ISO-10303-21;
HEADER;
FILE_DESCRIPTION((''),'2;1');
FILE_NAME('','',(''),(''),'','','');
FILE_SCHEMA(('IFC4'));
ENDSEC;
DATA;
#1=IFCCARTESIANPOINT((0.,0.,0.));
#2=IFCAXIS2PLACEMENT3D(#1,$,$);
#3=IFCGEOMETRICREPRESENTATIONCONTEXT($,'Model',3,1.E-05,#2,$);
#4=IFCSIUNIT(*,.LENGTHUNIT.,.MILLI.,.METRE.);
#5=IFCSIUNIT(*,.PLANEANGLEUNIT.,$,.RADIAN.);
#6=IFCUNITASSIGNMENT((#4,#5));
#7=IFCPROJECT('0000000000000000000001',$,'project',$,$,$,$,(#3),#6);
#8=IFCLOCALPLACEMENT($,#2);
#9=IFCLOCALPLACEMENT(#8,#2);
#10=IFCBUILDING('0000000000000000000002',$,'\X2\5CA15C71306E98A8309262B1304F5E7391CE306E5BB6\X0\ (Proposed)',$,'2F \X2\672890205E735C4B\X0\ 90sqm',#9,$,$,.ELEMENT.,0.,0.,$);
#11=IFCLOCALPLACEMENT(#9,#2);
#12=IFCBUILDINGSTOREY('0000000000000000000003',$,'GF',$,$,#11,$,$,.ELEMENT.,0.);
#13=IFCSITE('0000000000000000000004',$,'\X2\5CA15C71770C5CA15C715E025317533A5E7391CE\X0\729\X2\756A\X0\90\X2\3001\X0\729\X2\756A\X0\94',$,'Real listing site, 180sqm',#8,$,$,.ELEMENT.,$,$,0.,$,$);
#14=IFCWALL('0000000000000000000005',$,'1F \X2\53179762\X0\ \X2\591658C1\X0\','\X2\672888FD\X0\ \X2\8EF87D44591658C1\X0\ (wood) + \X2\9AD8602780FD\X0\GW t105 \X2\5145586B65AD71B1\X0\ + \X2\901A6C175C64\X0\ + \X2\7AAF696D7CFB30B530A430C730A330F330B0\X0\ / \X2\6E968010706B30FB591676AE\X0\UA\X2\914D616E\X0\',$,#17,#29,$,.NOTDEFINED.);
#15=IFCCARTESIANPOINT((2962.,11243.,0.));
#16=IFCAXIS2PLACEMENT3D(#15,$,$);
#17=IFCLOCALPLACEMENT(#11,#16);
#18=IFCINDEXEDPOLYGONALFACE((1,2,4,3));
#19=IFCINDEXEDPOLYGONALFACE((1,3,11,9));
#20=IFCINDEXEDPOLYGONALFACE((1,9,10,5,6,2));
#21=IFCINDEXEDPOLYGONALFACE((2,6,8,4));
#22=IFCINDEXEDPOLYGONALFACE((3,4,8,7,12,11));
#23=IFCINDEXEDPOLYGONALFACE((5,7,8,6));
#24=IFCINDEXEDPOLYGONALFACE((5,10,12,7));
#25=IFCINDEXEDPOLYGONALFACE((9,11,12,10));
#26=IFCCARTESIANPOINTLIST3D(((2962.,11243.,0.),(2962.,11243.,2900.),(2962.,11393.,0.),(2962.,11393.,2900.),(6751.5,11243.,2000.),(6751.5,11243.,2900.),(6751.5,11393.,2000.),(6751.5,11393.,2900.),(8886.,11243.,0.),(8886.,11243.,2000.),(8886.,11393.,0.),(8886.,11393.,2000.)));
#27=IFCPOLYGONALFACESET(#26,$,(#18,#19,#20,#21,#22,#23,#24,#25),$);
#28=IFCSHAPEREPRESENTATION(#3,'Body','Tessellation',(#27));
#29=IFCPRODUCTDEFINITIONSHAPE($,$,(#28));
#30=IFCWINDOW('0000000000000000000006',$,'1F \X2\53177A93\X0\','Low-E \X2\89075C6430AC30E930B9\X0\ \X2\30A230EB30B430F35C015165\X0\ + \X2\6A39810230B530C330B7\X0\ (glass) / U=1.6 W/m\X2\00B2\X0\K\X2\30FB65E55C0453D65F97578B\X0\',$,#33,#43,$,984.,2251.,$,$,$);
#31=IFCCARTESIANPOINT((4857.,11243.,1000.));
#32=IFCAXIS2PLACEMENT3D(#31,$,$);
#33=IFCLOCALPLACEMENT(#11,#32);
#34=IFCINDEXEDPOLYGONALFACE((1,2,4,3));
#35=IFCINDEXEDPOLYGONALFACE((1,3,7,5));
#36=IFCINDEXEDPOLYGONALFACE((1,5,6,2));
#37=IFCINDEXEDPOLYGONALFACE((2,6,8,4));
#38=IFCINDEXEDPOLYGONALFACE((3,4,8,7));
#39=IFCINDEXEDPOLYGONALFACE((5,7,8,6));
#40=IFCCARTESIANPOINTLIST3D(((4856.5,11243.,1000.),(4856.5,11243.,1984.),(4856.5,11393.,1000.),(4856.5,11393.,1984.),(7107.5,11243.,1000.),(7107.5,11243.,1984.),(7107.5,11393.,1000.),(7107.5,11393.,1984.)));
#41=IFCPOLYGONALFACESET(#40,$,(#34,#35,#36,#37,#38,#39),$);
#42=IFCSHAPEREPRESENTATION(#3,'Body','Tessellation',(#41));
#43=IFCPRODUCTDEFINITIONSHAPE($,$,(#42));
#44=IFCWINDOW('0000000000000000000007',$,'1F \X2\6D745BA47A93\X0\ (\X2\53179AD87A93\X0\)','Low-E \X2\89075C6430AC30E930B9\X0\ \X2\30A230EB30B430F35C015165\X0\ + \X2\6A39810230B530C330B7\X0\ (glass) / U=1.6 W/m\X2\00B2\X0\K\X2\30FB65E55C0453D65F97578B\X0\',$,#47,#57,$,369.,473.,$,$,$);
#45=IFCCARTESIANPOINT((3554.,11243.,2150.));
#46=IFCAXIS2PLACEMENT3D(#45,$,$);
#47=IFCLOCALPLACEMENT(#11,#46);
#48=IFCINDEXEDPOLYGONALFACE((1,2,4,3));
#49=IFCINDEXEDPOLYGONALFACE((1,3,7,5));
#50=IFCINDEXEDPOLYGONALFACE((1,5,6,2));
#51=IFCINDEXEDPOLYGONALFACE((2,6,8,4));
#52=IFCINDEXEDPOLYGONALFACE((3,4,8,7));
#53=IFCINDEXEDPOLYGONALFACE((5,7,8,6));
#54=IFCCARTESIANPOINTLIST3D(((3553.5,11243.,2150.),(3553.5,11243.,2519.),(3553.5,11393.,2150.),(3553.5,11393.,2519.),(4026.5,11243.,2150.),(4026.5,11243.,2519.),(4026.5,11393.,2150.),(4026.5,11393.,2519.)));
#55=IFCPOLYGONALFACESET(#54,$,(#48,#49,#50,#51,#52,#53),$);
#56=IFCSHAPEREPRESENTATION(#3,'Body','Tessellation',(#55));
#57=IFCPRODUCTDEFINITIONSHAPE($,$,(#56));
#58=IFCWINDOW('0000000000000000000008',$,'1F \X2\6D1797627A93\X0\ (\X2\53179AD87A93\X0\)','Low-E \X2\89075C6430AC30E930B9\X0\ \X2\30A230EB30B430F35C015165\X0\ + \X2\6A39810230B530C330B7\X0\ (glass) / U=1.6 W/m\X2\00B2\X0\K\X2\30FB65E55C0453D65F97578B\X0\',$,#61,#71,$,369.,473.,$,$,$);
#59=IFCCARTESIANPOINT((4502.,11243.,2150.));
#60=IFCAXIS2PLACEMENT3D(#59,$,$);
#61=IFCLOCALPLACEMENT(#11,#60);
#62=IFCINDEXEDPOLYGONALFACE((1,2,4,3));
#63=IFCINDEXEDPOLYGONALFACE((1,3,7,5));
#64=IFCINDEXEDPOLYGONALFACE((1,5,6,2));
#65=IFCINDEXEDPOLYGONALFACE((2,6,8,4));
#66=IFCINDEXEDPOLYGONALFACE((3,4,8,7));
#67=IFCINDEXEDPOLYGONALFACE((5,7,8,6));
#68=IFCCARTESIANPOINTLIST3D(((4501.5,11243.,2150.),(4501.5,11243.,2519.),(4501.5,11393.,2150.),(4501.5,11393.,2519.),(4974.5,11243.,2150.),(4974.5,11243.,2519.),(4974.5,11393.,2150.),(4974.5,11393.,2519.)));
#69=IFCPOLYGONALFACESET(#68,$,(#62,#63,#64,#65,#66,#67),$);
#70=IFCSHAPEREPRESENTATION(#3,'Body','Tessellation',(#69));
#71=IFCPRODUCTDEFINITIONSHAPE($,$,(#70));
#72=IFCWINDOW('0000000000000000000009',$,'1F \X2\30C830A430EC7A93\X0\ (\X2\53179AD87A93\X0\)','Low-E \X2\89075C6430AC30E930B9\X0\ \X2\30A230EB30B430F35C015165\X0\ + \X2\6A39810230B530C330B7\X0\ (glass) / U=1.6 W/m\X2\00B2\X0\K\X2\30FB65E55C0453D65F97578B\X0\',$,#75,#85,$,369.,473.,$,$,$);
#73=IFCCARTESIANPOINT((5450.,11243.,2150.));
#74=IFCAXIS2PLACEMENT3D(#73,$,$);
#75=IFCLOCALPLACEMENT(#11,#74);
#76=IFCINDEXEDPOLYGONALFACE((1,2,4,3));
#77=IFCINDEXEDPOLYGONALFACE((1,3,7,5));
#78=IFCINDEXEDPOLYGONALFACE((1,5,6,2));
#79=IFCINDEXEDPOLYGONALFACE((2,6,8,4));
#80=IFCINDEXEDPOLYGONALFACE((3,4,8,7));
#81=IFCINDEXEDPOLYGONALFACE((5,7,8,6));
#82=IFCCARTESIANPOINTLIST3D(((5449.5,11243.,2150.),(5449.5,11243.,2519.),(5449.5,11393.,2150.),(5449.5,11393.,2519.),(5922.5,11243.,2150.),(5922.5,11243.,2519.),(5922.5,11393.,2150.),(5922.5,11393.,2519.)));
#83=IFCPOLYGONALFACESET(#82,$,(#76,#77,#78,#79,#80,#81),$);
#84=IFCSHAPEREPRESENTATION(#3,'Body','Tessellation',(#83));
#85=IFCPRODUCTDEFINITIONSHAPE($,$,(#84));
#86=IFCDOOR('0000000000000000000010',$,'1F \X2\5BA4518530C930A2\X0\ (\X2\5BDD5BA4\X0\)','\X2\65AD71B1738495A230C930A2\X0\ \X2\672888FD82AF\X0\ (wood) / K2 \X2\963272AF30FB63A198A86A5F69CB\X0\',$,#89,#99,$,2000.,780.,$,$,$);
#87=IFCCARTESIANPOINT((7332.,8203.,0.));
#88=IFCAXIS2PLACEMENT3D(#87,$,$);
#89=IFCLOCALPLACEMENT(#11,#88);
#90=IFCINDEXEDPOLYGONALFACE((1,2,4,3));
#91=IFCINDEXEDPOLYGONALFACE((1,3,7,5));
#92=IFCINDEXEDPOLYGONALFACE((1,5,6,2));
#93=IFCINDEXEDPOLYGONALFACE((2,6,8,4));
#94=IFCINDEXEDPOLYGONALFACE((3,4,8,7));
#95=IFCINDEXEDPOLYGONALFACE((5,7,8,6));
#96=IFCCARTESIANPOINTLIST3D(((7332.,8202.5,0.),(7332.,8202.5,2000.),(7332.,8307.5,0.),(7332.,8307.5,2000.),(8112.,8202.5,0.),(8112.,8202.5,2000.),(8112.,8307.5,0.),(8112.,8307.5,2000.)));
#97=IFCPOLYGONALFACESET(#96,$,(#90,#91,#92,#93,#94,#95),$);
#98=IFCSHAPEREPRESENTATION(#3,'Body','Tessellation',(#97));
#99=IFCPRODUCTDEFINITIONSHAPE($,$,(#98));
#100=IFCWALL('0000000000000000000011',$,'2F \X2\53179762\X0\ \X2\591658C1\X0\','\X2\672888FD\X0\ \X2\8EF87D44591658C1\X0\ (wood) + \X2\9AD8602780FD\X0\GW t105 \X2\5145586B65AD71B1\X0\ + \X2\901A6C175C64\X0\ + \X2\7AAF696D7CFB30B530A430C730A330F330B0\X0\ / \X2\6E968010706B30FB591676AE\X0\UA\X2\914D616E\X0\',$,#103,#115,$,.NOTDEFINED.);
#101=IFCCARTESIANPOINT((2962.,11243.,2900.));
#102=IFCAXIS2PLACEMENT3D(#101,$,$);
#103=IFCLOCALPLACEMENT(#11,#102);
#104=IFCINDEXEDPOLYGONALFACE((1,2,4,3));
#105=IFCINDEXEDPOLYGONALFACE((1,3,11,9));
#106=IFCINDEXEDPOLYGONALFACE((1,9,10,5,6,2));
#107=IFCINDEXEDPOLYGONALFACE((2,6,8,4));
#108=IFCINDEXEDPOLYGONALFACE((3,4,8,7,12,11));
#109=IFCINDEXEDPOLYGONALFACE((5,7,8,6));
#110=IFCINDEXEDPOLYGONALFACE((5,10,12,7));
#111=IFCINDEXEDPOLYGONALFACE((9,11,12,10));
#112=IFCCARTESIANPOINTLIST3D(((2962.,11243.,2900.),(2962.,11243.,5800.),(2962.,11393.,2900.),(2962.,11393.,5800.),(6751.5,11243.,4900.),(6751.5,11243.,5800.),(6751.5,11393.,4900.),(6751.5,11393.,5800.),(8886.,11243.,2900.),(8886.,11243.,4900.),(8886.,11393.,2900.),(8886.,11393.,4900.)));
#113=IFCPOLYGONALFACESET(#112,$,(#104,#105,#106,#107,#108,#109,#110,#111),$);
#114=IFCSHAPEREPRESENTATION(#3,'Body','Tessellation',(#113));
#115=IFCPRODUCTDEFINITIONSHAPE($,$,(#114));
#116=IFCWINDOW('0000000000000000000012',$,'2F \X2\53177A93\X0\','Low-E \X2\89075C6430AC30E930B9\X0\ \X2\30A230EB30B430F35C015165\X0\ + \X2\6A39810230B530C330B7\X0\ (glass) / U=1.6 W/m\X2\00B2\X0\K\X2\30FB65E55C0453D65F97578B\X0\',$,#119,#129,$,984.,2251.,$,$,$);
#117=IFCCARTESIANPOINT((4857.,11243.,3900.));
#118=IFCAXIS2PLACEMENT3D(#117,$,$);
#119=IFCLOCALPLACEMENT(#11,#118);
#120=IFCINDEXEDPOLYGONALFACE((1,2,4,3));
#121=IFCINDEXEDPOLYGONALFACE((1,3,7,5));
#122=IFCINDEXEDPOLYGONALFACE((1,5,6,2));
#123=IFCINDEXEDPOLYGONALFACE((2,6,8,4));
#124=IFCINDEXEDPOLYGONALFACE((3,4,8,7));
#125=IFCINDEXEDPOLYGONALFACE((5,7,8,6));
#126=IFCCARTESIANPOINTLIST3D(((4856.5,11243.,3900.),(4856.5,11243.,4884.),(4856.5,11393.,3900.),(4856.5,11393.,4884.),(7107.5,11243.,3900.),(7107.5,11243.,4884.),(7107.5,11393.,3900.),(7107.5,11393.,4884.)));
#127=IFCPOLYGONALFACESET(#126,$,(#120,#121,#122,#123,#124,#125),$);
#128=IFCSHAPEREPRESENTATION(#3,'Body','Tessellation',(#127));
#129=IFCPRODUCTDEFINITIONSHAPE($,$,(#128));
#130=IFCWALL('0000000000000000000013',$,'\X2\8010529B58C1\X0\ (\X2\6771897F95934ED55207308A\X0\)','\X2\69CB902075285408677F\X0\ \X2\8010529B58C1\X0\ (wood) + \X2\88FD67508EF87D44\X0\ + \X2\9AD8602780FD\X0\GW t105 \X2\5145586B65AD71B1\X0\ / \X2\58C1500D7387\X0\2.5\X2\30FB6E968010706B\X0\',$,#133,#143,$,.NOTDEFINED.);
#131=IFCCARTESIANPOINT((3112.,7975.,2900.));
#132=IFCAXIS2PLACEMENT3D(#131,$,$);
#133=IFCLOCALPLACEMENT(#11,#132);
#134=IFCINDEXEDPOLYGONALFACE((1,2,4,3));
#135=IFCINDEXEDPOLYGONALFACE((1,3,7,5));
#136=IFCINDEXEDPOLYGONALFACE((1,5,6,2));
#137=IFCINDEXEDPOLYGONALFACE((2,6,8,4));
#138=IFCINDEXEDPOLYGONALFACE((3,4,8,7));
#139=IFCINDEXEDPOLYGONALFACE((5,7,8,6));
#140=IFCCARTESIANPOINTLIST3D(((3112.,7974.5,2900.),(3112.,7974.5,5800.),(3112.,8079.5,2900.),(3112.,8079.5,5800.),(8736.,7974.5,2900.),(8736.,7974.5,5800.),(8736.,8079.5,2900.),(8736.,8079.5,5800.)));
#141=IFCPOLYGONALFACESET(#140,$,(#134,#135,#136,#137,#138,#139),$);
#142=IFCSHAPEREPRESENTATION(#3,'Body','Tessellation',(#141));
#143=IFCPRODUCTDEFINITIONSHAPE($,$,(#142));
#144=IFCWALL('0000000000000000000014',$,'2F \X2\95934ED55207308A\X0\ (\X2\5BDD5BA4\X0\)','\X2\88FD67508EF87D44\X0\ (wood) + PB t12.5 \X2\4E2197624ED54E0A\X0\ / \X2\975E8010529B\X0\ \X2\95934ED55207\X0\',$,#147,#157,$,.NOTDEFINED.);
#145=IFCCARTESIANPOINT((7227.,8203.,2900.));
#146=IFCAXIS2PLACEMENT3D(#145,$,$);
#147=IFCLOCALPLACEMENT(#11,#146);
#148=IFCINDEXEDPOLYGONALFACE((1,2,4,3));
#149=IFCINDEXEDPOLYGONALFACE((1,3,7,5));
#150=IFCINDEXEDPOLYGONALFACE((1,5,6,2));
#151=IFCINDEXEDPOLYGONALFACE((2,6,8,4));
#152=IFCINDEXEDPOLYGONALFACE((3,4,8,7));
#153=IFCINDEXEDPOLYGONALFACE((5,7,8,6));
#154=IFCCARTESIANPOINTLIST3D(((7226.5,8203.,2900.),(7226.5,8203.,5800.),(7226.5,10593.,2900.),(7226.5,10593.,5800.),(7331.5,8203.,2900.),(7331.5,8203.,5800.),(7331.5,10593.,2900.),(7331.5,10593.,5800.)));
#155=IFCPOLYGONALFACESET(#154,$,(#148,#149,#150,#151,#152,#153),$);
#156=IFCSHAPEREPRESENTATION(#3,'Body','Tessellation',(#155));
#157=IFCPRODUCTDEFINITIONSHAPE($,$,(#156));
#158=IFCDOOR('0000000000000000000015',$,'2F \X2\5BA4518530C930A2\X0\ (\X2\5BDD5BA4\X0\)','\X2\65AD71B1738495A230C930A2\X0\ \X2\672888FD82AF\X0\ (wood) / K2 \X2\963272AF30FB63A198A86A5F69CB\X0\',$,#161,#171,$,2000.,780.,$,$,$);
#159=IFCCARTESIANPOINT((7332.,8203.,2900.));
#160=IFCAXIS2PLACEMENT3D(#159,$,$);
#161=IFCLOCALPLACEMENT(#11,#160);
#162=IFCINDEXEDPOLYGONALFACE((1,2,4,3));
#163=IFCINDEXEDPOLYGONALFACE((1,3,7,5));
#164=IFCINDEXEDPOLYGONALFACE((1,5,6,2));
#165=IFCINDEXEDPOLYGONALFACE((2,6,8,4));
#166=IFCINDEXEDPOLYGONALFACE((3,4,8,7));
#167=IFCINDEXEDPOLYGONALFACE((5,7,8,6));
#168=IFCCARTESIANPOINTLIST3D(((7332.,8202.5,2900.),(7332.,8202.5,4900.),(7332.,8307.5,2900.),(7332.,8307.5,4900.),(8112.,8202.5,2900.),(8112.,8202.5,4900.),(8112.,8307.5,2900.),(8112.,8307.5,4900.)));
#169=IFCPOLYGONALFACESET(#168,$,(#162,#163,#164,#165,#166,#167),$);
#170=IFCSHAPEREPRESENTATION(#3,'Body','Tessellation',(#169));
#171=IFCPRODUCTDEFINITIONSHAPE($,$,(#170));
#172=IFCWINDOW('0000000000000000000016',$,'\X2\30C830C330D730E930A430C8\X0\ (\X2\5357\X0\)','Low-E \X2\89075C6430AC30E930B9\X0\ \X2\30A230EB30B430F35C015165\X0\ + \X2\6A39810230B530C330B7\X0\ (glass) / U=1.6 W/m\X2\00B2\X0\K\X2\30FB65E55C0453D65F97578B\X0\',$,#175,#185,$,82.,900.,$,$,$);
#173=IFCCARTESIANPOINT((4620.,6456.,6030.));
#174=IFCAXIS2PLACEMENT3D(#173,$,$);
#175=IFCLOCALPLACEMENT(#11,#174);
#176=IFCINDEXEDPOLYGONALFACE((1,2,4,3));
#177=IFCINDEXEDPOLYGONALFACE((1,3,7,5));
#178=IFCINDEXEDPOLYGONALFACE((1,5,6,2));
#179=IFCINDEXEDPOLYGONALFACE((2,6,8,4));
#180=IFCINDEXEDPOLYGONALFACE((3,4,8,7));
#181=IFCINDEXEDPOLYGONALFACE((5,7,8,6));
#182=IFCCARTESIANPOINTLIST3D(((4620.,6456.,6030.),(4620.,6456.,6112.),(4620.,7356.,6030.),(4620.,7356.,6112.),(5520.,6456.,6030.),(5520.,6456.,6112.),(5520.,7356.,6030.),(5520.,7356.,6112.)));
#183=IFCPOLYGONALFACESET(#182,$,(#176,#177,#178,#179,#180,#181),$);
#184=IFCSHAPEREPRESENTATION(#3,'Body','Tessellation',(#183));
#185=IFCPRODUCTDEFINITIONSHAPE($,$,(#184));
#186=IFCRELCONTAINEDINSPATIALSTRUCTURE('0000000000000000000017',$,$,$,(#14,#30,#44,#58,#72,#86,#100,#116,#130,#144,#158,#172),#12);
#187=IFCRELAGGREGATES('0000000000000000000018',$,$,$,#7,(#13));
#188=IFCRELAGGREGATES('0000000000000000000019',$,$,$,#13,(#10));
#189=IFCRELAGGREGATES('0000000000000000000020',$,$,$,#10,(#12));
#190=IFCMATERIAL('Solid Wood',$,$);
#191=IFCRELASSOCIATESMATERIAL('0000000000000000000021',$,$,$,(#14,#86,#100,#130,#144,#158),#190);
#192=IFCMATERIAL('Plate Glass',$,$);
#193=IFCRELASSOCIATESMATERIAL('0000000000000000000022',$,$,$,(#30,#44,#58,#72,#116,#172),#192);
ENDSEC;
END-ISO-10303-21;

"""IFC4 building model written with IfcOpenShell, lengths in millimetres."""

from ifc_helpers import new_model, si_unit, frame, frame_2d, origin, place, context, project, spatial, rectangle, extrude, material, element, fill, save


model = new_model("IFC4")

# Units and contexts
model_context = context("Model", 3, precision=1e-05, world=origin())
ifc_project = project(units=[si_unit("LENGTHUNIT", "METRE", prefix="MILLI"), si_unit("PLANEANGLEUNIT", "RADIAN")], contexts=[model_context])

# Site, building, storey
site_placement = place(None, origin())
site = spatial("IfcSite", under=ifc_project, at=site_placement, Name="岡山県岡山市北区平野729番90、729番94", ObjectType="Real listing site, 180sqm", CompositionType="ELEMENT", RefElevation=0.0)
building_placement = place(site_placement, origin())
building = spatial("IfcBuilding", under=site, at=building_placement, Name="岡山の風を抱く平野の家 (Proposed)", ObjectType="2F 木造平屋 90sqm", CompositionType="ELEMENT", ElevationOfRefHeight=0.0, ElevationOfTerrain=0.0)
storey_placement = place(building_placement, origin())
storey = spatial("IfcBuildingStorey", under=building, at=storey_placement, Name="GF", CompositionType="ELEMENT", Elevation=0.0)

# Wall, openings, windows
ifc_material_1 = material(Name="Solid Wood")
wall_1_placement = place(storey_placement, frame((2962.0, 11243.0, 0.0)))
wall_1 = element("IfcWall", 1, at=wall_1_placement, inside=storey, material=ifc_material_1, Name="1F 北面 外壁", Description="木製 軸組外壁 (wood) + 高性能GW t105 充填断熱 + 通気層 + 窯業系サイディング / 準耐火・外皮UA配慮", PredefinedType="NOTDEFINED", context=model_context, shape_type="SweptSolid", body=[
    extrude(rectangle(XDim=5924.0, YDim=150.0, at=frame_2d((2962.0, 75.0))), frame((2962.0, 11243.0, 0.0)), (0.0, 0.0, 1.0), 2900.0),
])
opening_1_placement = place(storey_placement, frame((4857.0, 11243.0, 1000.0)))
opening_1 = element("IfcOpeningElement", 2, at=opening_1_placement, cuts=wall_1, PredefinedType="NOTDEFINED", context=model_context, shape_type="SweptSolid", body=[
    extrude(rectangle(XDim=2251.0, YDim=150.0, at=frame_2d((1125.0, 75.0))), frame((4857.0, 11243.0, 1000.0)), (0.0, 0.0, 1.0), 984.0),
])
opening_2_placement = place(storey_placement, frame((3554.0, 11243.0, 2150.0)))
opening_2 = element("IfcOpeningElement", 3, at=opening_2_placement, cuts=wall_1, PredefinedType="NOTDEFINED", context=model_context, shape_type="SweptSolid", body=[
    extrude(rectangle(XDim=473.0, YDim=150.0, at=frame_2d((236.0, 75.0))), frame((3554.0, 11243.0, 2150.0)), (0.0, 0.0, 1.0), 369.0),
])
opening_3_placement = place(storey_placement, frame((4502.0, 11243.0, 2150.0)))
opening_3 = element("IfcOpeningElement", 4, at=opening_3_placement, cuts=wall_1, PredefinedType="NOTDEFINED", context=model_context, shape_type="SweptSolid", body=[
    extrude(rectangle(XDim=473.0, YDim=150.0, at=frame_2d((236.0, 75.0))), frame((4502.0, 11243.0, 2150.0)), (0.0, 0.0, 1.0), 369.0),
])
opening_4_placement = place(storey_placement, frame((5450.0, 11243.0, 2150.0)))
opening_4 = element("IfcOpeningElement", 5, at=opening_4_placement, cuts=wall_1, PredefinedType="NOTDEFINED", context=model_context, shape_type="SweptSolid", body=[
    extrude(rectangle(XDim=473.0, YDim=150.0, at=frame_2d((236.0, 75.0))), frame((5450.0, 11243.0, 2150.0)), (0.0, 0.0, 1.0), 369.0),
])
ifc_material_2 = material(Name="Plate Glass")
window_1_placement = place(storey_placement, frame((4857.0, 11243.0, 1000.0)))
window_1 = element("IfcWindow", 6, at=window_1_placement, inside=storey, material=ifc_material_2, Name="1F 北窓", Description="Low-E 複層ガラス アルゴン封入 + 樹脂サッシ (glass) / U=1.6 W/m²K・日射取得型", OverallHeight=984.0, OverallWidth=2251.0, context=model_context, shape_type="SweptSolid", body=[
    extrude(rectangle(XDim=2251.0, YDim=150.0, at=frame_2d((1125.0, 75.0))), frame((4857.0, 11243.0, 1000.0)), (0.0, 0.0, 1.0), 984.0),
])
fill(opening_1, window_1)
window_2_placement = place(storey_placement, frame((3554.0, 11243.0, 2150.0)))
window_2 = element("IfcWindow", 7, at=window_2_placement, inside=storey, material=ifc_material_2, Name="1F 浴室窓 (北高窓)", Description="Low-E 複層ガラス アルゴン封入 + 樹脂サッシ (glass) / U=1.6 W/m²K・日射取得型", OverallHeight=369.0, OverallWidth=473.0, context=model_context, shape_type="SweptSolid", body=[
    extrude(rectangle(XDim=473.0, YDim=150.0, at=frame_2d((236.0, 75.0))), frame((3554.0, 11243.0, 2150.0)), (0.0, 0.0, 1.0), 369.0),
])
fill(opening_2, window_2)
window_3_placement = place(storey_placement, frame((4502.0, 11243.0, 2150.0)))
window_3 = element("IfcWindow", 8, at=window_3_placement, inside=storey, material=ifc_material_2, Name="1F 洗面窓 (北高窓)", Description="Low-E 複層ガラス アルゴン封入 + 樹脂サッシ (glass) / U=1.6 W/m²K・日射取得型", OverallHeight=369.0, OverallWidth=473.0, context=model_context, shape_type="SweptSolid", body=[
    extrude(rectangle(XDim=473.0, YDim=150.0, at=frame_2d((236.0, 75.0))), frame((4502.0, 11243.0, 2150.0)), (0.0, 0.0, 1.0), 369.0),
])
fill(opening_3, window_3)
window_4_placement = place(storey_placement, frame((5450.0, 11243.0, 2150.0)))
window_4 = element("IfcWindow", 9, at=window_4_placement, inside=storey, material=ifc_material_2, Name="1F トイレ窓 (北高窓)", Description="Low-E 複層ガラス アルゴン封入 + 樹脂サッシ (glass) / U=1.6 W/m²K・日射取得型", OverallHeight=369.0, OverallWidth=473.0, context=model_context, shape_type="SweptSolid", body=[
    extrude(rectangle(XDim=473.0, YDim=150.0, at=frame_2d((236.0, 75.0))), frame((5450.0, 11243.0, 2150.0)), (0.0, 0.0, 1.0), 369.0),
])
fill(opening_4, window_4)

# Door
door_1_placement = place(storey_placement, frame((7332.0, 8203.0, 0.0)))
element("IfcDoor", 10, at=door_1_placement, inside=storey, material=ifc_material_1, Name="1F 室内ドア (寝室)", Description="断熱玄関ドア 木製芯 (wood) / K2 防犯・採風機構", OverallHeight=2000.0, OverallWidth=780.0, context=model_context, shape_type="SweptSolid", body=[
    extrude(rectangle(XDim=780.0, YDim=105.0, at=frame_2d((390.0, 52.0))), frame((7332.0, 8203.0, 0.0)), (0.0, 0.0, 1.0), 2000.0),
])

# Wall, opening, window
wall_2_placement = place(storey_placement, frame((2962.0, 11243.0, 2900.0)))
wall_2 = element("IfcWall", 11, at=wall_2_placement, inside=storey, material=ifc_material_1, Name="2F 北面 外壁", Description="木製 軸組外壁 (wood) + 高性能GW t105 充填断熱 + 通気層 + 窯業系サイディング / 準耐火・外皮UA配慮", PredefinedType="NOTDEFINED", context=model_context, shape_type="SweptSolid", body=[
    extrude(rectangle(XDim=5924.0, YDim=150.0, at=frame_2d((2962.0, 75.0))), frame((2962.0, 11243.0, 2900.0)), (0.0, 0.0, 1.0), 2900.0),
])
opening_5_placement = place(storey_placement, frame((4857.0, 11243.0, 3900.0)))
opening_5 = element("IfcOpeningElement", 12, at=opening_5_placement, cuts=wall_2, PredefinedType="NOTDEFINED", context=model_context, shape_type="SweptSolid", body=[
    extrude(rectangle(XDim=2251.0, YDim=150.0, at=frame_2d((1125.0, 75.0))), frame((4857.0, 11243.0, 3900.0)), (0.0, 0.0, 1.0), 984.0),
])
window_5_placement = place(storey_placement, frame((4857.0, 11243.0, 3900.0)))
window_5 = element("IfcWindow", 13, at=window_5_placement, inside=storey, material=ifc_material_2, Name="2F 北窓", Description="Low-E 複層ガラス アルゴン封入 + 樹脂サッシ (glass) / U=1.6 W/m²K・日射取得型", OverallHeight=984.0, OverallWidth=2251.0, context=model_context, shape_type="SweptSolid", body=[
    extrude(rectangle(XDim=2251.0, YDim=150.0, at=frame_2d((1125.0, 75.0))), frame((4857.0, 11243.0, 3900.0)), (0.0, 0.0, 1.0), 984.0),
])
fill(opening_5, window_5)

# Walls
wall_3_placement = place(storey_placement, frame((3112.0, 7975.0, 2900.0)))
element("IfcWall", 14, at=wall_3_placement, inside=storey, material=ifc_material_1, Name="耐力壁 (東西間仕切り)", Description="構造用合板 耐力壁 (wood) + 製材軸組 + 高性能GW t105 充填断熱 / 壁倍率2.5・準耐火", PredefinedType="NOTDEFINED", context=model_context, shape_type="SweptSolid", body=[
    extrude(rectangle(XDim=5624.0, YDim=105.0, at=frame_2d((2812.0, 52.0))), frame((3112.0, 7975.0, 2900.0)), (0.0, 0.0, 1.0), 2900.0),
])
wall_4_placement = place(storey_placement, frame((7227.0, 8203.0, 2900.0)))
element("IfcWall", 15, at=wall_4_placement, inside=storey, material=ifc_material_1, Name="2F 間仕切り (寝室)", Description="製材軸組 (wood) + PB t12.5 両面仕上 / 非耐力 間仕切", PredefinedType="NOTDEFINED", context=model_context, shape_type="SweptSolid", body=[
    extrude(rectangle(XDim=105.0, YDim=2390.0, at=frame_2d((52.0, 1195.0))), frame((7227.0, 8203.0, 2900.0)), (0.0, 0.0, 1.0), 2900.0),
])

# Door
door_2_placement = place(storey_placement, frame((7332.0, 8203.0, 2900.0)))
element("IfcDoor", 16, at=door_2_placement, inside=storey, material=ifc_material_1, Name="2F 室内ドア (寝室)", Description="断熱玄関ドア 木製芯 (wood) / K2 防犯・採風機構", OverallHeight=2000.0, OverallWidth=780.0, context=model_context, shape_type="SweptSolid", body=[
    extrude(rectangle(XDim=780.0, YDim=105.0, at=frame_2d((390.0, 52.0))), frame((7332.0, 8203.0, 2900.0)), (0.0, 0.0, 1.0), 2000.0),
])

# Window
window_6_placement = place(storey_placement, frame((4620.0, 6456.0, 6030.0)))
element("IfcWindow", 17, at=window_6_placement, inside=storey, material=ifc_material_2, Name="トップライト (南)", Description="Low-E 複層ガラス アルゴン封入 + 樹脂サッシ (glass) / U=1.6 W/m²K・日射取得型", OverallHeight=82.0, OverallWidth=900.0, context=model_context, shape_type="SweptSolid", body=[
    extrude(rectangle(XDim=900.0, YDim=900.0, at=frame_2d((450.0, 450.0))), frame((4620.0, 6456.0, 6030.0)), (0.0, 0.0, 1.0), 82.0),
])

save(model, "model.ifc")
